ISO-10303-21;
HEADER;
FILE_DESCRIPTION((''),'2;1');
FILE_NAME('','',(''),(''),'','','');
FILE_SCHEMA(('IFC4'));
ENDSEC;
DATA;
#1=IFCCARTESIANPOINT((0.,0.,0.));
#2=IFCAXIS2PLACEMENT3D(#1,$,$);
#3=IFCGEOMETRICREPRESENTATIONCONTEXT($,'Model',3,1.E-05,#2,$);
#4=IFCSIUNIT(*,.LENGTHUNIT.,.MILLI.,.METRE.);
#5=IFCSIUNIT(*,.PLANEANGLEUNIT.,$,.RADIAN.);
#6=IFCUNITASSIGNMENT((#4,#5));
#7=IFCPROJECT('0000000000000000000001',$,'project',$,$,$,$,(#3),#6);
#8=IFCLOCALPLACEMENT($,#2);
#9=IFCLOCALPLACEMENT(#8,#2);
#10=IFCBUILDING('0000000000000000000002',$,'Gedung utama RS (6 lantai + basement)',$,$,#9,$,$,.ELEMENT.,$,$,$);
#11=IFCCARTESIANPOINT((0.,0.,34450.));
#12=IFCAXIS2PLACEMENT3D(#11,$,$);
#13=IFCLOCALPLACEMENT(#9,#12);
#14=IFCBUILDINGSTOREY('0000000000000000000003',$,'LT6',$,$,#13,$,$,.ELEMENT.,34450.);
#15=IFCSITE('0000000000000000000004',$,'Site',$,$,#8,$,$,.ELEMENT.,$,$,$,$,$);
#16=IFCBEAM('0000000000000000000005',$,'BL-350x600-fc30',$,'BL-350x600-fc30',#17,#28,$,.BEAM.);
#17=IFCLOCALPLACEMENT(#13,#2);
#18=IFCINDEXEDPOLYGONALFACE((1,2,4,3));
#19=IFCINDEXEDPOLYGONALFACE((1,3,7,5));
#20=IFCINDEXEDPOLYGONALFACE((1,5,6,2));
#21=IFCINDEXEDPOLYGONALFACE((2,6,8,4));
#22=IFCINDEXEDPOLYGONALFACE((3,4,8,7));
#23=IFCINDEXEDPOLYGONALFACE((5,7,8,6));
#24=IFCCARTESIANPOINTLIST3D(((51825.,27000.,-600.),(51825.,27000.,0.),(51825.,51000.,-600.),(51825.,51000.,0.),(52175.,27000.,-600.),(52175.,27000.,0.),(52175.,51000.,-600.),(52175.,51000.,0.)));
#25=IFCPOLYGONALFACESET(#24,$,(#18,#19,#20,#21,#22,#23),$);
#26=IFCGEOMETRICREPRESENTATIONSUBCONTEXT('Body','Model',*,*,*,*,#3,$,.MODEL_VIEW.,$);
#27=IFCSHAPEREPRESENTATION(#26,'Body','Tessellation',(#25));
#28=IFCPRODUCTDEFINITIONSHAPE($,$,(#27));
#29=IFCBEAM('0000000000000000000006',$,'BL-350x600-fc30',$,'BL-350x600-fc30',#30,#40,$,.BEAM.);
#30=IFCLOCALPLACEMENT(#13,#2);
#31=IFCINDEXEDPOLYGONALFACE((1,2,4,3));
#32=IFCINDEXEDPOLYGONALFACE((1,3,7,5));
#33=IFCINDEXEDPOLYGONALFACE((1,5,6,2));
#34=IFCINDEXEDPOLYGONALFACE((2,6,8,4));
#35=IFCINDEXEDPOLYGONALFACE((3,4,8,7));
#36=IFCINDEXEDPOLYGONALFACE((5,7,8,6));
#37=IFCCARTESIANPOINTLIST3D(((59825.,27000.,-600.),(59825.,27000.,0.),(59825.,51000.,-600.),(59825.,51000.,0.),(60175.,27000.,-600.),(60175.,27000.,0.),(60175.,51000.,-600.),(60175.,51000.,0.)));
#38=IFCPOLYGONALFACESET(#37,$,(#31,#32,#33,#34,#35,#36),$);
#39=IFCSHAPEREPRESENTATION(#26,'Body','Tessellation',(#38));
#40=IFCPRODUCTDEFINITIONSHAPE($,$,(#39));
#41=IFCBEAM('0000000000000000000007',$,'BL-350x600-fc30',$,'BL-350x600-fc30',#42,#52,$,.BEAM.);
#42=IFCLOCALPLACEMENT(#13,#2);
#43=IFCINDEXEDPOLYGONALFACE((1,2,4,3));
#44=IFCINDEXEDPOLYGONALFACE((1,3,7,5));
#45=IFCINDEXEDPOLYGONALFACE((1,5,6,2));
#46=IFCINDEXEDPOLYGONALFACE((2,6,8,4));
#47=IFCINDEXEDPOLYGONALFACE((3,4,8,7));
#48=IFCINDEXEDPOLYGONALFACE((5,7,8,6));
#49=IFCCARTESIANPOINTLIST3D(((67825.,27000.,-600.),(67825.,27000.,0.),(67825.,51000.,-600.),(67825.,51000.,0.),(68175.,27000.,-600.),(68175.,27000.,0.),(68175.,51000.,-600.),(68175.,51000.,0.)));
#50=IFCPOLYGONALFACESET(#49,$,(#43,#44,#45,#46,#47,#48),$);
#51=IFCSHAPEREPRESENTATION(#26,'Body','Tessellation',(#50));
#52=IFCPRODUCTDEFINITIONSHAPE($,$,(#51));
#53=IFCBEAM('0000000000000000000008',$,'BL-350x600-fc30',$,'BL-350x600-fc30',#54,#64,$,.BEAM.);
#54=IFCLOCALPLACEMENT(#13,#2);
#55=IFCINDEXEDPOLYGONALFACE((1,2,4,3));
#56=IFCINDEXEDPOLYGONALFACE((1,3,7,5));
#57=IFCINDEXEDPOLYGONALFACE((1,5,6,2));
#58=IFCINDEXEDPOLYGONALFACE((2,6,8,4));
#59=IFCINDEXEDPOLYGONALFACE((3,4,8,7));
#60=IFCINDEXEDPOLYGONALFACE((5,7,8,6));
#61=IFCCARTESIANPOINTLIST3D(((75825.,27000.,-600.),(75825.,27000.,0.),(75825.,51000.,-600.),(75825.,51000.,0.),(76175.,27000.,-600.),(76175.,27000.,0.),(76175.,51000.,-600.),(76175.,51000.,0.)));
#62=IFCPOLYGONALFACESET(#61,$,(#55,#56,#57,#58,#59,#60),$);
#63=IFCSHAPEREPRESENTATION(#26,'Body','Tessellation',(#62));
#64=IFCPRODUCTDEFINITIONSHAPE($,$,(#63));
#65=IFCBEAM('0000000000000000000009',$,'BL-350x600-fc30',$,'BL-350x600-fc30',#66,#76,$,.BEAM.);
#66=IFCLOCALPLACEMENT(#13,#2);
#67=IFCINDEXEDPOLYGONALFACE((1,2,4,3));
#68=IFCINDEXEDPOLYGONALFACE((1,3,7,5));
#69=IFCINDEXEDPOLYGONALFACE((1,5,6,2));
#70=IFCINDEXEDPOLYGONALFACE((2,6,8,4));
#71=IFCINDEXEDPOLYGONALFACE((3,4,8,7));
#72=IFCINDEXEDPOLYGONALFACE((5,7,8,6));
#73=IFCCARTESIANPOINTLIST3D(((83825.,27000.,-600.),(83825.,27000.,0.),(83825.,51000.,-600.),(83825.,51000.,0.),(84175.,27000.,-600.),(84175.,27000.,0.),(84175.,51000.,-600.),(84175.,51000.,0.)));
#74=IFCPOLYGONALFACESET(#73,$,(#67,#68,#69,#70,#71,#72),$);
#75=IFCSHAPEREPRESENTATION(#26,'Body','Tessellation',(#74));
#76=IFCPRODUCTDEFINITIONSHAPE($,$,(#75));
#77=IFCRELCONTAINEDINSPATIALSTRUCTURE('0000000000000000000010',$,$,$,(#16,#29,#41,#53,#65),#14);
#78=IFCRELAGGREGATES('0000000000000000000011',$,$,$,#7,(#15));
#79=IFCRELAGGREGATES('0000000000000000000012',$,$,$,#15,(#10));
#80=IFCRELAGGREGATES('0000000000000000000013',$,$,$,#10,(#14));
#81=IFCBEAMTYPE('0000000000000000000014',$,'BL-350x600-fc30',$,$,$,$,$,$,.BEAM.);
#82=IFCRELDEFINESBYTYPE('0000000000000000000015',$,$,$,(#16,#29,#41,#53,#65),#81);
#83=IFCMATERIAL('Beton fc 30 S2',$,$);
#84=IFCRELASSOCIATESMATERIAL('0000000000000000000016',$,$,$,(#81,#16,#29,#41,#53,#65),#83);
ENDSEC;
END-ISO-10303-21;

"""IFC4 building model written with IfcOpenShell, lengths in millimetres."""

from ifc_helpers import new_model, si_unit, frame, origin, origin_2d, place, context, subcontext, project, spatial, rectangle, extrude, material, material_profile, profile_set, profile_usage, type_object, element, save


model = new_model("IFC4")

# Units and contexts
model_context = context("Model", 3, precision=1e-05, world=origin())
body_context = subcontext(model_context, "Body", "Model", "MODEL_VIEW")
ifc_project = project(units=[si_unit("LENGTHUNIT", "METRE", prefix="MILLI"), si_unit("PLANEANGLEUNIT", "RADIAN")], contexts=[model_context])

# Site, building, storey
site_placement = place(None, origin())
site = spatial("IfcSite", under=ifc_project, at=site_placement, Name="Site", CompositionType="ELEMENT")
building_placement = place(site_placement, origin())
building = spatial("IfcBuilding", under=site, at=building_placement, Name="Gedung utama RS (6 lantai + basement)", CompositionType="ELEMENT")
storey_placement = place(building_placement, frame((0.0, 0.0, 34450.0)))
storey = spatial("IfcBuildingStorey", under=building, at=storey_placement, Name="LT6", CompositionType="ELEMENT", Elevation=34450.0)

# Beams
ifc_material = material(Name="Beton fc 30 S2")
ifc_material_profile_1 = material_profile(ifc_material, rectangle(XDim=350.0, YDim=600.0, at=origin_2d()), Name="BL-350x600-fc30")
ifc_profile_set_1 = profile_set([ifc_material_profile_1], Name="BL-350x600-fc30")
ifc_profile_usage_1 = profile_usage(ifc_profile_set_1, cardinal=8)
beam_type = type_object("IfcBeamType", Name="BL-350x600-fc30", PredefinedType="BEAM", material=ifc_profile_set_1)
for number, where, name in (
    (1, (52000.0, 27000.0, -300.0), "BL-350x600-fc30"),
    (2, (60000.0, 27000.0, -300.0), "BL-350x600-fc30"),
    (3, (68000.0, 27000.0, -300.0), "BL-350x600-fc30"),
    (4, (76000.0, 27000.0, -300.0), "BL-350x600-fc30"),
    (5, (84000.0, 27000.0, -300.0), "BL-350x600-fc30"),
):
    element("IfcBeam", number, at=place(storey_placement, frame(where)), inside=storey, type_object=beam_type, material=ifc_profile_usage_1, Name=name, ObjectType="BL-350x600-fc30", PredefinedType="BEAM", context=body_context, shape_type="SweptSolid", body=[
        extrude(rectangle(XDim=350.0, YDim=600.0, at=origin_2d()), frame((0.0, 0.0, 0.0), z_axis=(0.0, 1.0, 0.0), x_axis=(-1.0, 0.0, 0.0)), (0.0, 0.0, 1.0), 24000.0),
    ])

save(model, "model.ifc")
